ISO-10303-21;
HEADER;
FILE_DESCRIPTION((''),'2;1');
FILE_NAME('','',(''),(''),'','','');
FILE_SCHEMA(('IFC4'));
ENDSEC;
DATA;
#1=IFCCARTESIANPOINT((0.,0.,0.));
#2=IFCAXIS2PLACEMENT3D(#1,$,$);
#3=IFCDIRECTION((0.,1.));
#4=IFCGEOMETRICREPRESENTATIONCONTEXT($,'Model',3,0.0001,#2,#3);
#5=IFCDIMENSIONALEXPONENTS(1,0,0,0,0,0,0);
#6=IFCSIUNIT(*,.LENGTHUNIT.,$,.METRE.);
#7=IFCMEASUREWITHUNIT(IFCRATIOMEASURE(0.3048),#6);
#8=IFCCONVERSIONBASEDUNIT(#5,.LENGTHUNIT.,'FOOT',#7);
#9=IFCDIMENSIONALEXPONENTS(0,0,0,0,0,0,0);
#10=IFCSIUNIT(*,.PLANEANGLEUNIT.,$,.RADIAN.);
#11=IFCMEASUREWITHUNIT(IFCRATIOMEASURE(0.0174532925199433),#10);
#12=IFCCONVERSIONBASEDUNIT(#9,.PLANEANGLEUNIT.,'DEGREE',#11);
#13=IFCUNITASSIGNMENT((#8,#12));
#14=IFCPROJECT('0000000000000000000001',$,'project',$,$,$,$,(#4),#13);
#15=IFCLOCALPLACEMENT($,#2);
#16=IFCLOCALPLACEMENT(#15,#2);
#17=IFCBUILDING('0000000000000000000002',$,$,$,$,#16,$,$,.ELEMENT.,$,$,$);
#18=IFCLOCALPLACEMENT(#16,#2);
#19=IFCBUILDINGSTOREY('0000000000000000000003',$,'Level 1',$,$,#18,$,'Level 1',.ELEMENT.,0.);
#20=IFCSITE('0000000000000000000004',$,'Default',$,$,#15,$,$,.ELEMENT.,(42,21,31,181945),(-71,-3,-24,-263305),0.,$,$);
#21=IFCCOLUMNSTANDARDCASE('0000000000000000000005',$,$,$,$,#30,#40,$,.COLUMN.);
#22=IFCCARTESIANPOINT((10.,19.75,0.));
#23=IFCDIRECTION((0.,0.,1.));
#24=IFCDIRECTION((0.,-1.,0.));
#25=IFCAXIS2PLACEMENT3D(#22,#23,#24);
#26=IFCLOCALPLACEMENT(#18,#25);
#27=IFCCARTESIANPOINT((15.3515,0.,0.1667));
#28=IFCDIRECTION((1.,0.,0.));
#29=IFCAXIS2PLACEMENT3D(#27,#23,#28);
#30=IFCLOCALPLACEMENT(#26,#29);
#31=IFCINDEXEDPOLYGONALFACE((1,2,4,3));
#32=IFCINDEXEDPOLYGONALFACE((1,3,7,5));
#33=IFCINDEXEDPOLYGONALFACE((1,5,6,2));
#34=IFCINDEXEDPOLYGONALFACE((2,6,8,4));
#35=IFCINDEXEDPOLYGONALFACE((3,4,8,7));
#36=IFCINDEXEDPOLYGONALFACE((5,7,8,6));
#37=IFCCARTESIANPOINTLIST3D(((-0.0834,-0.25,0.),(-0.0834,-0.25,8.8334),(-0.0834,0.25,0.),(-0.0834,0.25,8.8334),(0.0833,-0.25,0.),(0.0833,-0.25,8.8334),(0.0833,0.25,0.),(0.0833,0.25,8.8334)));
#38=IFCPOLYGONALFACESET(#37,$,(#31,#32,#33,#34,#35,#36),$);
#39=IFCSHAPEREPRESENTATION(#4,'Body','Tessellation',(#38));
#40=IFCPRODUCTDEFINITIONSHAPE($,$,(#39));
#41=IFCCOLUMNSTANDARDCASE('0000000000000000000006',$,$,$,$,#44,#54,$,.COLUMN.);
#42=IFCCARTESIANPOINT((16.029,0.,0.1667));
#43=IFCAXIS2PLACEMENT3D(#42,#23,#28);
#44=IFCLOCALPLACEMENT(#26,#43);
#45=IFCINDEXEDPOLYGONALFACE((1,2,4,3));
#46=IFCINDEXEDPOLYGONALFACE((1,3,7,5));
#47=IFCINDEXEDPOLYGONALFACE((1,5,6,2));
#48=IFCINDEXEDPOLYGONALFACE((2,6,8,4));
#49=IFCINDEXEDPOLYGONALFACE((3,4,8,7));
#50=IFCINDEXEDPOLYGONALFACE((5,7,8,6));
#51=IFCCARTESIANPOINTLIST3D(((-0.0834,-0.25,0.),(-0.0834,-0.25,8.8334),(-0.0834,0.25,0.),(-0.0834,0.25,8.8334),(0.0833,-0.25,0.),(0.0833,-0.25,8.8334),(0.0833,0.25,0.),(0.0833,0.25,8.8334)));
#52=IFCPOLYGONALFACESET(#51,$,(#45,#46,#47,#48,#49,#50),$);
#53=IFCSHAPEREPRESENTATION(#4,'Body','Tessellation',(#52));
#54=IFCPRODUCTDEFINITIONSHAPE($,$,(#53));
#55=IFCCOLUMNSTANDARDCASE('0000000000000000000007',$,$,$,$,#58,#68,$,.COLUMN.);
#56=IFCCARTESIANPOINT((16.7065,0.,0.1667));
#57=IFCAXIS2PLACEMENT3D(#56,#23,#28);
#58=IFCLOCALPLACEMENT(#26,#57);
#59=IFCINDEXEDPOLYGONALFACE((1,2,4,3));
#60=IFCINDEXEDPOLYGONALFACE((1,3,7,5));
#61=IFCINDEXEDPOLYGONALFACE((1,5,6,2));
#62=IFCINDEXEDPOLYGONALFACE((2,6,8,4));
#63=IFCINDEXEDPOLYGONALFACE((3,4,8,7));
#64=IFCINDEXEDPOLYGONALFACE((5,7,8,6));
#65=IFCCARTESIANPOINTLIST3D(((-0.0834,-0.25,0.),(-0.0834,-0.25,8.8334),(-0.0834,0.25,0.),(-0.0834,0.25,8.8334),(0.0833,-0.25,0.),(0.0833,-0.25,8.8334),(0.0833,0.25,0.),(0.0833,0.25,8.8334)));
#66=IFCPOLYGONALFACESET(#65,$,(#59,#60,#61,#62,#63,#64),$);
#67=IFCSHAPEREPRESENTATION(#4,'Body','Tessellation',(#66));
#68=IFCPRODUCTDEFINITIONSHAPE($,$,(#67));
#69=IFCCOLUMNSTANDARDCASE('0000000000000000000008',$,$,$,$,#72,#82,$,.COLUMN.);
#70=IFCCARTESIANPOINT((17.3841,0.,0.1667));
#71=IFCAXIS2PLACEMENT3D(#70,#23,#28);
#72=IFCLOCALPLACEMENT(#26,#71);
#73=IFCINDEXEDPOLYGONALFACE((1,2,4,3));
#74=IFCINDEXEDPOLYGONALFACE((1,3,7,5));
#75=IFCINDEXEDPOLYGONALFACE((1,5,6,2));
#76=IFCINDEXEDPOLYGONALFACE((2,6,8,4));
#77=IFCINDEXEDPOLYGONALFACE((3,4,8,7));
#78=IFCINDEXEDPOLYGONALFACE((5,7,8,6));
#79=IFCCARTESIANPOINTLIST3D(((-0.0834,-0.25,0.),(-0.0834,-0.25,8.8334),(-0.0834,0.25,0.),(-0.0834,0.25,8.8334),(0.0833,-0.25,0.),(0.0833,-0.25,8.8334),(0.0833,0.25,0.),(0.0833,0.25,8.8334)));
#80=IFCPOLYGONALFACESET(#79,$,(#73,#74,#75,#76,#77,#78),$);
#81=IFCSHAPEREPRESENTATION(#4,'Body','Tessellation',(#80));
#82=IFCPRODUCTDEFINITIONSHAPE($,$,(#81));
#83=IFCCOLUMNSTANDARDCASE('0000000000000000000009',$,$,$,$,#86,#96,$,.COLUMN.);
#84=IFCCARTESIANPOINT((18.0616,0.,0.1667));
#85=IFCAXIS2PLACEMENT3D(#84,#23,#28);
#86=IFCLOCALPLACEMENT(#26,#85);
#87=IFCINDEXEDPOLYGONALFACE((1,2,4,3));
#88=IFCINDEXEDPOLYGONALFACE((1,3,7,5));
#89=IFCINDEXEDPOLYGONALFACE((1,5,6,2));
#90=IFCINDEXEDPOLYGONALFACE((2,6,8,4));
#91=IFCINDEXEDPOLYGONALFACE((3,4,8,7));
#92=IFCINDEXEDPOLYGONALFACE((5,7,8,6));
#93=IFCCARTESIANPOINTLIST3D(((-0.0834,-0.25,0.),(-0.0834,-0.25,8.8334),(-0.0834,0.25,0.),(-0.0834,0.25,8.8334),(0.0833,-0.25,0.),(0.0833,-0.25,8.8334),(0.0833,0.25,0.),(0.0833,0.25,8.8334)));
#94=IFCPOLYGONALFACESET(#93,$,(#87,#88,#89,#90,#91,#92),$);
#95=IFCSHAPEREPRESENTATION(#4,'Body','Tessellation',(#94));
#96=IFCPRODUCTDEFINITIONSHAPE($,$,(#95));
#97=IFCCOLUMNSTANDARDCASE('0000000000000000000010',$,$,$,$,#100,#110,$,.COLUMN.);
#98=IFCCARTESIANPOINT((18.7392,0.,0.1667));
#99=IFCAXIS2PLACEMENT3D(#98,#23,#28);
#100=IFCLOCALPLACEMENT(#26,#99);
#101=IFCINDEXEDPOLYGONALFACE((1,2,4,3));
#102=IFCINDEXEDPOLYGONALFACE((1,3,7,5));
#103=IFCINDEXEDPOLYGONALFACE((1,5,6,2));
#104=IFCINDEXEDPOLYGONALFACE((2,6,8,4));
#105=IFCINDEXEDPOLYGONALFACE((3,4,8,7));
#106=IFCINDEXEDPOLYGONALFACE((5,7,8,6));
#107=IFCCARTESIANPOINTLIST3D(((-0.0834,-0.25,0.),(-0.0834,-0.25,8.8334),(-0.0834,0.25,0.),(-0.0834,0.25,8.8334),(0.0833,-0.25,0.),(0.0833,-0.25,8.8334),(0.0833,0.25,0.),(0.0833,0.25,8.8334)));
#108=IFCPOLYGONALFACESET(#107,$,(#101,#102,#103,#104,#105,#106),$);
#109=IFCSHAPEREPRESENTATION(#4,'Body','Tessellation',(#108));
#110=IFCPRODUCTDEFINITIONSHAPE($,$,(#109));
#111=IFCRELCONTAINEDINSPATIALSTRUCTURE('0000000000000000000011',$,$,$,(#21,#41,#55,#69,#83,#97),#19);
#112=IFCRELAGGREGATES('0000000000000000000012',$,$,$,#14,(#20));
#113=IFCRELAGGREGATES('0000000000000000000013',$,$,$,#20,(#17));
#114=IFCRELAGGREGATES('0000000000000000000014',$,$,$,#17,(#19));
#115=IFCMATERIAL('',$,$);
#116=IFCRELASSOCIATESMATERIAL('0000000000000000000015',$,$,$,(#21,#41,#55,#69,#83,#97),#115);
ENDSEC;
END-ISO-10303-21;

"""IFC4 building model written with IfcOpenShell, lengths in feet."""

from ifc_helpers import new_model, entity, si_unit, converted_unit, direction, frame, origin, place, context, project, spatial, rectangle, extrude, material, element, save


model = new_model("IFC4")

# Units and contexts
model_context = context("Model", 3, precision=0.0001, world=origin(), true_north=direction((0.0, 1.0)))
ifc_project = project(units=[converted_unit("LENGTHUNIT", "FOOT", entity("IfcRatioMeasure", 0.3048), si_unit("LENGTHUNIT", "METRE"), dimensions=[1, 0, 0, 0, 0, 0, 0]), converted_unit("PLANEANGLEUNIT", "DEGREE", entity("IfcRatioMeasure", 0.0174532925199433), si_unit("PLANEANGLEUNIT", "RADIAN"), dimensions=[0, 0, 0, 0, 0, 0, 0])], contexts=[model_context])

# Site, building, storey
site_placement = place(None, origin())
site = spatial("IfcSite", under=ifc_project, at=site_placement, Name="Default", CompositionType="ELEMENT", RefLatitude=(42, 21, 31, 181945), RefLongitude=(-71, -3, -24, -263305), RefElevation=0.0)
building_placement = place(site_placement, origin())
building = spatial("IfcBuilding", under=site, at=building_placement, CompositionType="ELEMENT")
storey_placement = place(building_placement, origin())
storey = spatial("IfcBuildingStorey", under=building, at=storey_placement, Name="Level 1", LongName="Level 1", CompositionType="ELEMENT", Elevation=0.0)

# Columns
ifc_material_1 = material(Name="")
placement_1 = place(storey_placement, frame((10.0, 19.75, 0.0), z_axis=(0.0, 0.0, 1.0), x_axis=(0.0, -1.0, 0.0)))
for number, where, z_axis, x_axis in (
    (1, (15.3515, 0.0, 0.1667), (0.0, 0.0, 1.0), (1.0, 0.0, 0.0)),
    (2, (16.029, 0.0, 0.1667), (0.0, 0.0, 1.0), (1.0, 0.0, 0.0)),
    (3, (16.7065, 0.0, 0.1667), (0.0, 0.0, 1.0), (1.0, 0.0, 0.0)),
    (4, (17.3841, 0.0, 0.1667), (0.0, 0.0, 1.0), (1.0, 0.0, 0.0)),
    (5, (18.0616, 0.0, 0.1667), (0.0, 0.0, 1.0), (1.0, 0.0, 0.0)),
    (6, (18.7392, 0.0, 0.1667), (0.0, 0.0, 1.0), (1.0, 0.0, 0.0)),
):
    element("IfcColumnStandardCase", number, at=place(placement_1, frame(where, z_axis=z_axis, x_axis=x_axis)), inside=storey, material=ifc_material_1, PredefinedType="COLUMN", context=model_context, shape_type="SweptSolid", body=[
        extrude(rectangle(XDim=0.1667, YDim=0.5), origin(), (0.0, 0.0, 1.0), 8.8334),
    ])

save(model, "model.ifc")
